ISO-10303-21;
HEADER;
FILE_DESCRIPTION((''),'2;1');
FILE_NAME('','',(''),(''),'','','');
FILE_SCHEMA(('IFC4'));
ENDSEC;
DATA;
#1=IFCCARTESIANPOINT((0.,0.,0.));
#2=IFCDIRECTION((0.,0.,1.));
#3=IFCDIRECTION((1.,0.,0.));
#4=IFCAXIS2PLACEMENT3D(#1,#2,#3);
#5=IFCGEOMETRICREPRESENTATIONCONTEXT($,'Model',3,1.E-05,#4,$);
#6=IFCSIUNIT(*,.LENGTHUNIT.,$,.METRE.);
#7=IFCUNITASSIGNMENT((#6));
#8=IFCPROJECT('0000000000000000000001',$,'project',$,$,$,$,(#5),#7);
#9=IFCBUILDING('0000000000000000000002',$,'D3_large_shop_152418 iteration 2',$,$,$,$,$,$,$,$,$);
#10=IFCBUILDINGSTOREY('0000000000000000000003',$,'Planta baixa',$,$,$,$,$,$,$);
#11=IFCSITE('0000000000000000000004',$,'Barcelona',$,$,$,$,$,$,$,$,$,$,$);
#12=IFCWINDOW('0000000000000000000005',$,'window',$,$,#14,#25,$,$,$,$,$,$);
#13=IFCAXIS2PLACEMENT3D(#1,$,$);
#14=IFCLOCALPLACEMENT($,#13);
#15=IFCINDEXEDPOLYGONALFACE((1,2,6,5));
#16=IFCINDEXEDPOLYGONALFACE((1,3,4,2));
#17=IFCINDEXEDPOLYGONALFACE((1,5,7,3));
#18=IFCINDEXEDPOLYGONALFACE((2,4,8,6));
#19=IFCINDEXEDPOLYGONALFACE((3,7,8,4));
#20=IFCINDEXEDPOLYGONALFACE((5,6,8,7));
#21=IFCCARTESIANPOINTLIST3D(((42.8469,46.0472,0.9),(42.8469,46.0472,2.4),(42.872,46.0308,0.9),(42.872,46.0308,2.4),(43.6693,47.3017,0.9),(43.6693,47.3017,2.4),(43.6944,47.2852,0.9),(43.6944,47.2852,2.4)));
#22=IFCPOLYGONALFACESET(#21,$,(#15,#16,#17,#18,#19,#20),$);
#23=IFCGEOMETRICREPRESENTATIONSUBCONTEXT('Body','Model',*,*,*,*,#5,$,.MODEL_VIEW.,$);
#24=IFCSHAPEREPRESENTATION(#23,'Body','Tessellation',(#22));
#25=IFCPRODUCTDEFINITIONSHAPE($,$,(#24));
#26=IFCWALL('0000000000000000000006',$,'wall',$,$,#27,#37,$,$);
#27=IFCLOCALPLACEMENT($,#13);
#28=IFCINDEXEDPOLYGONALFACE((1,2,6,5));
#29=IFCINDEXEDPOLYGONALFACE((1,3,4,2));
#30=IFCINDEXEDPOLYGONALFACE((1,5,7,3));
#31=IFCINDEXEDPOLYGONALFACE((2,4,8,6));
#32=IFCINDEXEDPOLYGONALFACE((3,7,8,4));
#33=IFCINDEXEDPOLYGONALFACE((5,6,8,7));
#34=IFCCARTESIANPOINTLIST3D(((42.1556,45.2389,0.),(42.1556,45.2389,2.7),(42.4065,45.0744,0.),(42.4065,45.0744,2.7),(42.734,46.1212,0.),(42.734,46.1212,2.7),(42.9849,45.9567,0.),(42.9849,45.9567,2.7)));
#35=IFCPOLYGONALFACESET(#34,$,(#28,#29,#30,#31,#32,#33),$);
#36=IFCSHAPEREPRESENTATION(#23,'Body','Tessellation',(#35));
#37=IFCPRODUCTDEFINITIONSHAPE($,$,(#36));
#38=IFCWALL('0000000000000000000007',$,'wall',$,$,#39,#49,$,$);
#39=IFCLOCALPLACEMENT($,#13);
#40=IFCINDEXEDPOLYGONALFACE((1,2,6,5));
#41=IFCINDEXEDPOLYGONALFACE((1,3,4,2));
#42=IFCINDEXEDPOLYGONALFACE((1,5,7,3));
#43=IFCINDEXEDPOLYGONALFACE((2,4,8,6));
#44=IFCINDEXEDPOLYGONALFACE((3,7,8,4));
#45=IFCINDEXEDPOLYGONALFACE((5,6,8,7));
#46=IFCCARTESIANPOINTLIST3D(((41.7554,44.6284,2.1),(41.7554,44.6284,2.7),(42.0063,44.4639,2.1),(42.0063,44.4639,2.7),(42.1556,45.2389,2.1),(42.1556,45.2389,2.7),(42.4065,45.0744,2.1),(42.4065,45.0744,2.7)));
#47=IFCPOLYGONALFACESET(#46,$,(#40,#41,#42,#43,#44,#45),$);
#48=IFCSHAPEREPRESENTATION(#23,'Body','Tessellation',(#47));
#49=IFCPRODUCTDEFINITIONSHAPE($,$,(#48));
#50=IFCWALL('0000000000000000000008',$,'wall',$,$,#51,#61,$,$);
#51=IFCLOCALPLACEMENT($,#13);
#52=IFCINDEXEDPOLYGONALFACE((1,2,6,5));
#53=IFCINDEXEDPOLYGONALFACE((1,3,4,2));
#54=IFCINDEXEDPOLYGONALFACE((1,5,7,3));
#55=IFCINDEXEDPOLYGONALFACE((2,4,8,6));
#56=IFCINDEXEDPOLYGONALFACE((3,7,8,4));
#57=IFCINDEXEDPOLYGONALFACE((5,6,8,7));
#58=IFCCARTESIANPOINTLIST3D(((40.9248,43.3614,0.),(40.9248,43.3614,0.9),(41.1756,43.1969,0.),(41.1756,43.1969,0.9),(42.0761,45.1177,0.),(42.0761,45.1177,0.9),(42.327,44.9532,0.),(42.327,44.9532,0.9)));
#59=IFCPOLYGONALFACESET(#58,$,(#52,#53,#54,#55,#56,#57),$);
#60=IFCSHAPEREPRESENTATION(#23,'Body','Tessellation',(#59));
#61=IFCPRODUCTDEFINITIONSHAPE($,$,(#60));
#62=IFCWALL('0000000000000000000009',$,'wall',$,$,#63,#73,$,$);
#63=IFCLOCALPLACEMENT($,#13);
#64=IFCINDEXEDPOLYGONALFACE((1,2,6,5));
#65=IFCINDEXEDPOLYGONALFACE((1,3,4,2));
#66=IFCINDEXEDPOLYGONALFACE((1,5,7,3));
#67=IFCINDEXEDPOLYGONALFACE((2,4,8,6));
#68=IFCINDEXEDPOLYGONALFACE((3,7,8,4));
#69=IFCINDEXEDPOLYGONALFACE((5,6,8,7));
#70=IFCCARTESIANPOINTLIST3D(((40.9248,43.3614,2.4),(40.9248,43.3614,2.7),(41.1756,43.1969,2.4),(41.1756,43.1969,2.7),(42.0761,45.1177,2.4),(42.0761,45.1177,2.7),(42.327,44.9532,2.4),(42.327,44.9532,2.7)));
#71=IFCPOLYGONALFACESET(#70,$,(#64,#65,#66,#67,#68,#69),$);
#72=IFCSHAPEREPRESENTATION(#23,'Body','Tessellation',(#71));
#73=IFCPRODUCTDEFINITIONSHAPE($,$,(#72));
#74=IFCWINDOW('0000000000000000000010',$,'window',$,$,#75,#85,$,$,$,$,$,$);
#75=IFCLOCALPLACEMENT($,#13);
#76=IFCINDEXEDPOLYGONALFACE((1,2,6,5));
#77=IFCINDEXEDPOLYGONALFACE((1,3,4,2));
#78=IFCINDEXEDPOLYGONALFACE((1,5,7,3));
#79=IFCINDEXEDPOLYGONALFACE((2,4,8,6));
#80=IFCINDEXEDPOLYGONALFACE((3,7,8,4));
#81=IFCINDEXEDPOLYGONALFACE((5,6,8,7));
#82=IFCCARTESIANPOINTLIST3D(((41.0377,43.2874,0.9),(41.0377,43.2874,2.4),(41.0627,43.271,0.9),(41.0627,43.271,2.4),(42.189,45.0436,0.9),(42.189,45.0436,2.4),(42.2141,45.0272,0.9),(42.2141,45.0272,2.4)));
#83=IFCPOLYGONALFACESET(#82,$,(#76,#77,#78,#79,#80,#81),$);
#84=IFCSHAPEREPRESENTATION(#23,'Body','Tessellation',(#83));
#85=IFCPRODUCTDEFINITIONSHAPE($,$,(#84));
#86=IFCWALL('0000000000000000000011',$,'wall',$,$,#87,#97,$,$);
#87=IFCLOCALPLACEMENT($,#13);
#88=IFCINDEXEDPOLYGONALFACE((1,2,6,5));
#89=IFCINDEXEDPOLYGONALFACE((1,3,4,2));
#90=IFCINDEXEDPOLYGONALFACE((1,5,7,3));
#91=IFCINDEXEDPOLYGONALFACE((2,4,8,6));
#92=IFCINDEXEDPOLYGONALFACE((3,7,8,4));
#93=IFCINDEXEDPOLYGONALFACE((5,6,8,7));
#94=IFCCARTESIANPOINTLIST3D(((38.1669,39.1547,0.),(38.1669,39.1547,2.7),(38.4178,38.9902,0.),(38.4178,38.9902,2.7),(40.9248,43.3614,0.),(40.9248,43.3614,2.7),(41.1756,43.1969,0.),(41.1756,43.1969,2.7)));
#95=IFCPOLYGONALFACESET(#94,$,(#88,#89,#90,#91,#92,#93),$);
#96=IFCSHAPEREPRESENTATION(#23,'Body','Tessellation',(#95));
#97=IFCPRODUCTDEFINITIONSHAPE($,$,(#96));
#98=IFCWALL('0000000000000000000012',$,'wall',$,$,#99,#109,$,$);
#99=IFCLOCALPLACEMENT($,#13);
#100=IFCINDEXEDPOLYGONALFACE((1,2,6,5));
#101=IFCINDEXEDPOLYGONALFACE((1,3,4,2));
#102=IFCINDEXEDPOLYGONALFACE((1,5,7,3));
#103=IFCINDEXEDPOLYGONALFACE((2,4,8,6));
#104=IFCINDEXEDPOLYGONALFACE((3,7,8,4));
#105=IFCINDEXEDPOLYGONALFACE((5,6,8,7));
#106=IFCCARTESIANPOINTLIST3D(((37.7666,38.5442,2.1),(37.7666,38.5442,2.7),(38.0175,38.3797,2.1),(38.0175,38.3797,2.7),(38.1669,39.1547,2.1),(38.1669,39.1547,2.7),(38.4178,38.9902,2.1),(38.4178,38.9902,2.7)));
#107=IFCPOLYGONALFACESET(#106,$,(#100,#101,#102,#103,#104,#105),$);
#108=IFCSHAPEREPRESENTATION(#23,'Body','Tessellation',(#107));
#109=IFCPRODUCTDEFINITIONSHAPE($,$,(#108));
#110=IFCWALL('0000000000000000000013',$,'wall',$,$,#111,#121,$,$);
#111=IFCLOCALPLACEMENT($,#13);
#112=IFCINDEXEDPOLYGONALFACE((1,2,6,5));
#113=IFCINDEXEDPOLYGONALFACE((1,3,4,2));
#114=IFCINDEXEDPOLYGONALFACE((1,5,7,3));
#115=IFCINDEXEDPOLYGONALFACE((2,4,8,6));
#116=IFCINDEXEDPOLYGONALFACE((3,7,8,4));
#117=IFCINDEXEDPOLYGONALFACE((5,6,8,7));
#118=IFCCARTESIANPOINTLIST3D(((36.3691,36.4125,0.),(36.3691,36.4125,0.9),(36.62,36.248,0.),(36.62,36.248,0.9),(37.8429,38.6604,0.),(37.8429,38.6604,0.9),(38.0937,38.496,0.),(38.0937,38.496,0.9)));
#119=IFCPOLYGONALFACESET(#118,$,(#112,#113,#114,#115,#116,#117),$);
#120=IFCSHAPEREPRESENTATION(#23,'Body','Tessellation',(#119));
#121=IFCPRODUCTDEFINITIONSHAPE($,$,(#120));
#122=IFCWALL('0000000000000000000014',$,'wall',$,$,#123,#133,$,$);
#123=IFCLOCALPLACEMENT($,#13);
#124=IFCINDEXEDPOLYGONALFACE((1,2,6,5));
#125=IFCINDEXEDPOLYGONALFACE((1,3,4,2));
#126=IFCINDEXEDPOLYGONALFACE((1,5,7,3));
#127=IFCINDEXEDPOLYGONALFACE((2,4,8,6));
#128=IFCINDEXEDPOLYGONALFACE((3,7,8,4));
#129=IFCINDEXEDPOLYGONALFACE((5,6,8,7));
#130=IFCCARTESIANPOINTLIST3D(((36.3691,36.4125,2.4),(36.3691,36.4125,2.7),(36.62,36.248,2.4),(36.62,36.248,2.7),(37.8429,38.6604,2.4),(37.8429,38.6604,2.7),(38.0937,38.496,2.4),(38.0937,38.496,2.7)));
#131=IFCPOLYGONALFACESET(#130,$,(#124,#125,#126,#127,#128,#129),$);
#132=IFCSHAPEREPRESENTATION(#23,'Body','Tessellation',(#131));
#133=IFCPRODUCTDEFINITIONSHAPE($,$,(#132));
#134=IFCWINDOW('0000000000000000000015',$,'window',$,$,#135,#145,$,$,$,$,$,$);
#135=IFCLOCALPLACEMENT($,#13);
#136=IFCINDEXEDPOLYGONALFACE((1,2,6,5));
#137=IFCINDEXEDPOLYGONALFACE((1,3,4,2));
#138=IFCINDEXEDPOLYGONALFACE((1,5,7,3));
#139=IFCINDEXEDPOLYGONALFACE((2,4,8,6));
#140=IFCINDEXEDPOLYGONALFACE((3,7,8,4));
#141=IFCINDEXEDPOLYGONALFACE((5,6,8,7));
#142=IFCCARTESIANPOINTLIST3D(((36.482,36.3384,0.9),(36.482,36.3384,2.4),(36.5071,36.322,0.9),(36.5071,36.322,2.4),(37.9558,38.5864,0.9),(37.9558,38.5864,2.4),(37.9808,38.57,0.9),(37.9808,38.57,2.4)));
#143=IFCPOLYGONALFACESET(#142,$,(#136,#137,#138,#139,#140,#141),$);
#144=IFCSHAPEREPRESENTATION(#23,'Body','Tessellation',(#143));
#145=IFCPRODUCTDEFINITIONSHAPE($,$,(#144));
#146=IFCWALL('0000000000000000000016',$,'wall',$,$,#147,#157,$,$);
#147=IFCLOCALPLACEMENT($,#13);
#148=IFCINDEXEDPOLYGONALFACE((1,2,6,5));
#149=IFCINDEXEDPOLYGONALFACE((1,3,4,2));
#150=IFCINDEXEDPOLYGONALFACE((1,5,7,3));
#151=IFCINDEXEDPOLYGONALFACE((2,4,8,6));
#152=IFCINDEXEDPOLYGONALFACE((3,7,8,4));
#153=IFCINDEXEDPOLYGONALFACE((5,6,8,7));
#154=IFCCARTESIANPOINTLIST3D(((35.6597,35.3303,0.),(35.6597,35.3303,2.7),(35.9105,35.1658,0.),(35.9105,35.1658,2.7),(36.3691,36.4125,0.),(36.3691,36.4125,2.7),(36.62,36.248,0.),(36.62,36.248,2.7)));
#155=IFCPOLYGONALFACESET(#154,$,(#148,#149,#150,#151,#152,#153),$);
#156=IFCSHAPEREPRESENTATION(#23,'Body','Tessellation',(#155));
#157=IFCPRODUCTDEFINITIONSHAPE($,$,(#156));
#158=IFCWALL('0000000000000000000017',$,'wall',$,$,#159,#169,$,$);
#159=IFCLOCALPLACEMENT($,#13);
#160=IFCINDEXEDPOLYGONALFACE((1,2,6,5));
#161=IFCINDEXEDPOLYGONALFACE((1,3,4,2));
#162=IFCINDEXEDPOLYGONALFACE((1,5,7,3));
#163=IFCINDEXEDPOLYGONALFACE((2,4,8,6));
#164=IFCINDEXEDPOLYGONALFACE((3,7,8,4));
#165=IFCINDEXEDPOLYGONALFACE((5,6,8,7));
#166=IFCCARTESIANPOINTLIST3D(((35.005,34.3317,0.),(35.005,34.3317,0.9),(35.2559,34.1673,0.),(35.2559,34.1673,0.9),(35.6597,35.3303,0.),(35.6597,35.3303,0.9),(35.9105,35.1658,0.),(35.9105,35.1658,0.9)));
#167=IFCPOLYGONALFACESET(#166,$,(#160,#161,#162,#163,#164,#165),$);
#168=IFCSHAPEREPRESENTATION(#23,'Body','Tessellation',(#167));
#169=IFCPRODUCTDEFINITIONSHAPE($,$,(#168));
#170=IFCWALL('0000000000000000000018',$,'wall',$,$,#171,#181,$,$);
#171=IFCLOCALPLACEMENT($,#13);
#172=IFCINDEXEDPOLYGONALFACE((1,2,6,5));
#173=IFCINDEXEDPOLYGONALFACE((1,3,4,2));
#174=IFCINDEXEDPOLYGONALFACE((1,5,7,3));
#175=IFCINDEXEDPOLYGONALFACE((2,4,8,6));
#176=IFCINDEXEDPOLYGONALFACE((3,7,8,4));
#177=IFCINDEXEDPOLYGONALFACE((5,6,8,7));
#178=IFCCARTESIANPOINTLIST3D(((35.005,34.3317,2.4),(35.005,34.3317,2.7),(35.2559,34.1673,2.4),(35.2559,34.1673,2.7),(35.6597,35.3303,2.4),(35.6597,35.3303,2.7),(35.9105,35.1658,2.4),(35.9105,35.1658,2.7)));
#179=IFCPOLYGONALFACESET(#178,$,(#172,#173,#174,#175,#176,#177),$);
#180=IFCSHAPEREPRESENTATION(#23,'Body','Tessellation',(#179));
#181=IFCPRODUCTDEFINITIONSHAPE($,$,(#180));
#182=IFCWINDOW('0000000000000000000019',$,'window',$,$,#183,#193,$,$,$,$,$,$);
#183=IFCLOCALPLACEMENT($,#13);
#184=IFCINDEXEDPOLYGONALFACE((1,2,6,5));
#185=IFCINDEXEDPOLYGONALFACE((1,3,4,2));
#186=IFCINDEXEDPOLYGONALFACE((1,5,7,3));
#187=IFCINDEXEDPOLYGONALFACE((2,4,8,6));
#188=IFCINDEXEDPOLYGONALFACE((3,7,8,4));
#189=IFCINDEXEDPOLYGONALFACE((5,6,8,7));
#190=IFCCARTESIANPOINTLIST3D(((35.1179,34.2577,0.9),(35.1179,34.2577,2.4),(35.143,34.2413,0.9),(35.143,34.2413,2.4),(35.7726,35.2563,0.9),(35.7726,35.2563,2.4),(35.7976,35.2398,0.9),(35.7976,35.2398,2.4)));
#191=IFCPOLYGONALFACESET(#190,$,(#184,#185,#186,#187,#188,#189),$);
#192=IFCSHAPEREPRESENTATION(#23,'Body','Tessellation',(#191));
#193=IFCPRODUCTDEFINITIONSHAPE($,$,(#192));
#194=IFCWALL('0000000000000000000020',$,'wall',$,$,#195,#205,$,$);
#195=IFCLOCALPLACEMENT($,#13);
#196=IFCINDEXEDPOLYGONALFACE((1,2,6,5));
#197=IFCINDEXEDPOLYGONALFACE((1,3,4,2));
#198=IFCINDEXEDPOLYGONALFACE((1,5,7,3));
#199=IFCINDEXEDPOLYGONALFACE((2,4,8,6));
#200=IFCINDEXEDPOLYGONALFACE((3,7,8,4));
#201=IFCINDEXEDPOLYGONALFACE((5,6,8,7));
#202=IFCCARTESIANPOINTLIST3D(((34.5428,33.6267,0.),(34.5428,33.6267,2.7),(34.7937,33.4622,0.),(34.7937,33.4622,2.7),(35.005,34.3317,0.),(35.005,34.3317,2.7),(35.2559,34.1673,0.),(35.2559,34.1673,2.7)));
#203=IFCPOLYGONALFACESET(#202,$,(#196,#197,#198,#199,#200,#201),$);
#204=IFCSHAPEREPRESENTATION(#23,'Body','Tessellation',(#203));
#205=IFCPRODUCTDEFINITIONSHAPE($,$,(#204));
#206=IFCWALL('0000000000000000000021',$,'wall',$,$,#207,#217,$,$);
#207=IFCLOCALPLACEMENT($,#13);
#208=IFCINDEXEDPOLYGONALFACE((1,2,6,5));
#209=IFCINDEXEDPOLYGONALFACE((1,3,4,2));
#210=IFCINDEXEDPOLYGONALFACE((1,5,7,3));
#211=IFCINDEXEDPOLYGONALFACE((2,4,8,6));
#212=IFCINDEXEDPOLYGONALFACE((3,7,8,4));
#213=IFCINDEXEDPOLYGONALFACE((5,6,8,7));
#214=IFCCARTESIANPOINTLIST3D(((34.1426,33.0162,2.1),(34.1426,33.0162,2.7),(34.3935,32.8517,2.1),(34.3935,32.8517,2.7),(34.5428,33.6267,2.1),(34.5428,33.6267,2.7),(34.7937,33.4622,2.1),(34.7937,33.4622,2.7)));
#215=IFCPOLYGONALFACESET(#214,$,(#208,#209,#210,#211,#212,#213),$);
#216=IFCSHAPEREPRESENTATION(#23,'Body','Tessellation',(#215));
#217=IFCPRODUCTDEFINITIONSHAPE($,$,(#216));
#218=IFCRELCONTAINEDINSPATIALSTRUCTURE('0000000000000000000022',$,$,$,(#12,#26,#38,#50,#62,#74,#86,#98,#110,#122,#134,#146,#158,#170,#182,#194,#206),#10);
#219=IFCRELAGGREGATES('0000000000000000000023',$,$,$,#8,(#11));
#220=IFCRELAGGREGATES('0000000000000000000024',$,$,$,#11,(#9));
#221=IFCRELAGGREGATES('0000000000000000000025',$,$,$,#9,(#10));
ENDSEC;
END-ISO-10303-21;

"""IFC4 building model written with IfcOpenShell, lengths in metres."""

from ifc_helpers import new_model, si_unit, frame, origin, origin_with_axes, place, context, subcontext, project, spatial, polyline, outline, extrude, element, save


model = new_model("IFC4")

# Units and contexts
model_context = context("Model", 3, precision=1e-05, world=origin_with_axes())
body_context = subcontext(model_context, "Body", "Model", "MODEL_VIEW")
ifc_project = project(units=[si_unit("LENGTHUNIT", "METRE")], contexts=[model_context])

# Site, building, storey
site = spatial("IfcSite", under=ifc_project, Name="Barcelona")
building = spatial("IfcBuilding", under=site, Name="D3_large_shop_152418 iteration 2")
storey = spatial("IfcBuildingStorey", under=building, Name="Planta baixa")

# Window
window_1_placement = place(None, origin_with_axes())
element("IfcWindow", 1, at=window_1_placement, inside=storey, Name="window", context=body_context, shape_type="SweptSolid", body=[
    extrude(outline(polyline([(43.6944, 47.2852), (42.872, 46.0308), (42.8469, 46.0472), (43.6693, 47.3017), (43.6944, 47.2852)])), frame((0.0, 0.0, 0.9)), (0.0, 0.0, 1.0), 1.5),
])

# Walls
wall_1_placement = place(None, origin_with_axes())
element("IfcWall", 2, at=wall_1_placement, inside=storey, Name="wall", context=body_context, shape_type="SweptSolid", body=[
    extrude(outline(polyline([(42.9849, 45.9567), (42.4065, 45.0744), (42.1556, 45.2389), (42.734, 46.1212), (42.9849, 45.9567)])), origin(), (0.0, 0.0, 1.0), 2.7),
])
wall_2_placement = place(None, origin_with_axes())
element("IfcWall", 3, at=wall_2_placement, inside=storey, Name="wall", context=body_context, shape_type="SweptSolid", body=[
    extrude(outline(polyline([(42.4065, 45.0744), (42.0063, 44.4639), (41.7554, 44.6284), (42.1556, 45.2389), (42.4065, 45.0744)])), frame((0.0, 0.0, 2.1)), (0.0, 0.0, 1.0), 0.6),
])
wall_3_placement = place(None, origin_with_axes())
element("IfcWall", 4, at=wall_3_placement, inside=storey, Name="wall", context=body_context, shape_type="SweptSolid", body=[
    extrude(outline(polyline([(42.327, 44.9532), (41.1756, 43.1969), (40.9248, 43.3614), (42.0761, 45.1177), (42.327, 44.9532)])), origin(), (0.0, 0.0, 1.0), 0.9),
])
wall_4_placement = place(None, origin_with_axes())
element("IfcWall", 5, at=wall_4_placement, inside=storey, Name="wall", context=body_context, shape_type="SweptSolid", body=[
    extrude(outline(polyline([(42.327, 44.9532), (41.1756, 43.1969), (40.9248, 43.3614), (42.0761, 45.1177), (42.327, 44.9532)])), frame((0.0, 0.0, 2.4)), (0.0, 0.0, 1.0), 0.3),
])

# Window
window_2_placement = place(None, origin_with_axes())
element("IfcWindow", 6, at=window_2_placement, inside=storey, Name="window", context=body_context, shape_type="SweptSolid", body=[
    extrude(outline(polyline([(42.2141, 45.0272), (41.0627, 43.271), (41.0377, 43.2874), (42.189, 45.0436), (42.2141, 45.0272)])), frame((0.0, 0.0, 0.9)), (0.0, 0.0, 1.0), 1.5),
])

# Walls
wall_5_placement = place(None, origin_with_axes())
element("IfcWall", 7, at=wall_5_placement, inside=storey, Name="wall", context=body_context, shape_type="SweptSolid", body=[
    extrude(outline(polyline([(41.1756, 43.1969), (38.4178, 38.9902), (38.1669, 39.1547), (40.9248, 43.3614), (41.1756, 43.1969)])), origin(), (0.0, 0.0, 1.0), 2.7),
])
wall_6_placement = place(None, origin_with_axes())
element("IfcWall", 8, at=wall_6_placement, inside=storey, Name="wall", context=body_context, shape_type="SweptSolid", body=[
    extrude(outline(polyline([(38.4178, 38.9902), (38.0175, 38.3797), (37.7666, 38.5442), (38.1669, 39.1547), (38.4178, 38.9902)])), frame((0.0, 0.0, 2.1)), (0.0, 0.0, 1.0), 0.6),
])
wall_7_placement = place(None, origin_with_axes())
element("IfcWall", 9, at=wall_7_placement, inside=storey, Name="wall", context=body_context, shape_type="SweptSolid", body=[
    extrude(outline(polyline([(38.0937, 38.496), (36.62, 36.248), (36.3691, 36.4125), (37.8429, 38.6604), (38.0937, 38.496)])), origin(), (0.0, 0.0, 1.0), 0.9),
])
wall_8_placement = place(None, origin_with_axes())
element("IfcWall", 10, at=wall_8_placement, inside=storey, Name="wall", context=body_context, shape_type="SweptSolid", body=[
    extrude(outline(polyline([(38.0937, 38.496), (36.62, 36.248), (36.3691, 36.4125), (37.8429, 38.6604), (38.0937, 38.496)])), frame((0.0, 0.0, 2.4)), (0.0, 0.0, 1.0), 0.3),
])

# Window
window_3_placement = place(None, origin_with_axes())
element("IfcWindow", 11, at=window_3_placement, inside=storey, Name="window", context=body_context, shape_type="SweptSolid", body=[
    extrude(outline(polyline([(37.9808, 38.57), (36.5071, 36.322), (36.482, 36.3384), (37.9558, 38.5864), (37.9808, 38.57)])), frame((0.0, 0.0, 0.9)), (0.0, 0.0, 1.0), 1.5),
])

# Walls
wall_9_placement = place(None, origin_with_axes())
element("IfcWall", 12, at=wall_9_placement, inside=storey, Name="wall", context=body_context, shape_type="SweptSolid", body=[
    extrude(outline(polyline([(36.62, 36.248), (35.9105, 35.1658), (35.6597, 35.3303), (36.3691, 36.4125), (36.62, 36.248)])), origin(), (0.0, 0.0, 1.0), 2.7),
])
wall_10_placement = place(None, origin_with_axes())
element("IfcWall", 13, at=wall_10_placement, inside=storey, Name="wall", context=body_context, shape_type="SweptSolid", body=[
    extrude(outline(polyline([(35.9105, 35.1658), (35.2559, 34.1673), (35.005, 34.3317), (35.6597, 35.3303), (35.9105, 35.1658)])), origin(), (0.0, 0.0, 1.0), 0.9),
])
wall_11_placement = place(None, origin_with_axes())
element("IfcWall", 14, at=wall_11_placement, inside=storey, Name="wall", context=body_context, shape_type="SweptSolid", body=[
    extrude(outline(polyline([(35.9105, 35.1658), (35.2559, 34.1673), (35.005, 34.3317), (35.6597, 35.3303), (35.9105, 35.1658)])), frame((0.0, 0.0, 2.4)), (0.0, 0.0, 1.0), 0.3),
])

# Window
window_4_placement = place(None, origin_with_axes())
element("IfcWindow", 15, at=window_4_placement, inside=storey, Name="window", context=body_context, shape_type="SweptSolid", body=[
    extrude(outline(polyline([(35.7976, 35.2398), (35.143, 34.2413), (35.1179, 34.2577), (35.7726, 35.2563), (35.7976, 35.2398)])), frame((0.0, 0.0, 0.9)), (0.0, 0.0, 1.0), 1.5),
])

# Walls
wall_12_placement = place(None, origin_with_axes())
element("IfcWall", 16, at=wall_12_placement, inside=storey, Name="wall", context=body_context, shape_type="SweptSolid", body=[
    extrude(outline(polyline([(35.2559, 34.1673), (34.7937, 33.4622), (34.5428, 33.6267), (35.005, 34.3317), (35.2559, 34.1673)])), origin(), (0.0, 0.0, 1.0), 2.7),
])
wall_13_placement = place(None, origin_with_axes())
element("IfcWall", 17, at=wall_13_placement, inside=storey, Name="wall", context=body_context, shape_type="SweptSolid", body=[
    extrude(outline(polyline([(34.7937, 33.4622), (34.3935, 32.8517), (34.1426, 33.0162), (34.5428, 33.6267), (34.7937, 33.4622)])), frame((0.0, 0.0, 2.1)), (0.0, 0.0, 1.0), 0.6),
])

save(model, "model.ifc")
